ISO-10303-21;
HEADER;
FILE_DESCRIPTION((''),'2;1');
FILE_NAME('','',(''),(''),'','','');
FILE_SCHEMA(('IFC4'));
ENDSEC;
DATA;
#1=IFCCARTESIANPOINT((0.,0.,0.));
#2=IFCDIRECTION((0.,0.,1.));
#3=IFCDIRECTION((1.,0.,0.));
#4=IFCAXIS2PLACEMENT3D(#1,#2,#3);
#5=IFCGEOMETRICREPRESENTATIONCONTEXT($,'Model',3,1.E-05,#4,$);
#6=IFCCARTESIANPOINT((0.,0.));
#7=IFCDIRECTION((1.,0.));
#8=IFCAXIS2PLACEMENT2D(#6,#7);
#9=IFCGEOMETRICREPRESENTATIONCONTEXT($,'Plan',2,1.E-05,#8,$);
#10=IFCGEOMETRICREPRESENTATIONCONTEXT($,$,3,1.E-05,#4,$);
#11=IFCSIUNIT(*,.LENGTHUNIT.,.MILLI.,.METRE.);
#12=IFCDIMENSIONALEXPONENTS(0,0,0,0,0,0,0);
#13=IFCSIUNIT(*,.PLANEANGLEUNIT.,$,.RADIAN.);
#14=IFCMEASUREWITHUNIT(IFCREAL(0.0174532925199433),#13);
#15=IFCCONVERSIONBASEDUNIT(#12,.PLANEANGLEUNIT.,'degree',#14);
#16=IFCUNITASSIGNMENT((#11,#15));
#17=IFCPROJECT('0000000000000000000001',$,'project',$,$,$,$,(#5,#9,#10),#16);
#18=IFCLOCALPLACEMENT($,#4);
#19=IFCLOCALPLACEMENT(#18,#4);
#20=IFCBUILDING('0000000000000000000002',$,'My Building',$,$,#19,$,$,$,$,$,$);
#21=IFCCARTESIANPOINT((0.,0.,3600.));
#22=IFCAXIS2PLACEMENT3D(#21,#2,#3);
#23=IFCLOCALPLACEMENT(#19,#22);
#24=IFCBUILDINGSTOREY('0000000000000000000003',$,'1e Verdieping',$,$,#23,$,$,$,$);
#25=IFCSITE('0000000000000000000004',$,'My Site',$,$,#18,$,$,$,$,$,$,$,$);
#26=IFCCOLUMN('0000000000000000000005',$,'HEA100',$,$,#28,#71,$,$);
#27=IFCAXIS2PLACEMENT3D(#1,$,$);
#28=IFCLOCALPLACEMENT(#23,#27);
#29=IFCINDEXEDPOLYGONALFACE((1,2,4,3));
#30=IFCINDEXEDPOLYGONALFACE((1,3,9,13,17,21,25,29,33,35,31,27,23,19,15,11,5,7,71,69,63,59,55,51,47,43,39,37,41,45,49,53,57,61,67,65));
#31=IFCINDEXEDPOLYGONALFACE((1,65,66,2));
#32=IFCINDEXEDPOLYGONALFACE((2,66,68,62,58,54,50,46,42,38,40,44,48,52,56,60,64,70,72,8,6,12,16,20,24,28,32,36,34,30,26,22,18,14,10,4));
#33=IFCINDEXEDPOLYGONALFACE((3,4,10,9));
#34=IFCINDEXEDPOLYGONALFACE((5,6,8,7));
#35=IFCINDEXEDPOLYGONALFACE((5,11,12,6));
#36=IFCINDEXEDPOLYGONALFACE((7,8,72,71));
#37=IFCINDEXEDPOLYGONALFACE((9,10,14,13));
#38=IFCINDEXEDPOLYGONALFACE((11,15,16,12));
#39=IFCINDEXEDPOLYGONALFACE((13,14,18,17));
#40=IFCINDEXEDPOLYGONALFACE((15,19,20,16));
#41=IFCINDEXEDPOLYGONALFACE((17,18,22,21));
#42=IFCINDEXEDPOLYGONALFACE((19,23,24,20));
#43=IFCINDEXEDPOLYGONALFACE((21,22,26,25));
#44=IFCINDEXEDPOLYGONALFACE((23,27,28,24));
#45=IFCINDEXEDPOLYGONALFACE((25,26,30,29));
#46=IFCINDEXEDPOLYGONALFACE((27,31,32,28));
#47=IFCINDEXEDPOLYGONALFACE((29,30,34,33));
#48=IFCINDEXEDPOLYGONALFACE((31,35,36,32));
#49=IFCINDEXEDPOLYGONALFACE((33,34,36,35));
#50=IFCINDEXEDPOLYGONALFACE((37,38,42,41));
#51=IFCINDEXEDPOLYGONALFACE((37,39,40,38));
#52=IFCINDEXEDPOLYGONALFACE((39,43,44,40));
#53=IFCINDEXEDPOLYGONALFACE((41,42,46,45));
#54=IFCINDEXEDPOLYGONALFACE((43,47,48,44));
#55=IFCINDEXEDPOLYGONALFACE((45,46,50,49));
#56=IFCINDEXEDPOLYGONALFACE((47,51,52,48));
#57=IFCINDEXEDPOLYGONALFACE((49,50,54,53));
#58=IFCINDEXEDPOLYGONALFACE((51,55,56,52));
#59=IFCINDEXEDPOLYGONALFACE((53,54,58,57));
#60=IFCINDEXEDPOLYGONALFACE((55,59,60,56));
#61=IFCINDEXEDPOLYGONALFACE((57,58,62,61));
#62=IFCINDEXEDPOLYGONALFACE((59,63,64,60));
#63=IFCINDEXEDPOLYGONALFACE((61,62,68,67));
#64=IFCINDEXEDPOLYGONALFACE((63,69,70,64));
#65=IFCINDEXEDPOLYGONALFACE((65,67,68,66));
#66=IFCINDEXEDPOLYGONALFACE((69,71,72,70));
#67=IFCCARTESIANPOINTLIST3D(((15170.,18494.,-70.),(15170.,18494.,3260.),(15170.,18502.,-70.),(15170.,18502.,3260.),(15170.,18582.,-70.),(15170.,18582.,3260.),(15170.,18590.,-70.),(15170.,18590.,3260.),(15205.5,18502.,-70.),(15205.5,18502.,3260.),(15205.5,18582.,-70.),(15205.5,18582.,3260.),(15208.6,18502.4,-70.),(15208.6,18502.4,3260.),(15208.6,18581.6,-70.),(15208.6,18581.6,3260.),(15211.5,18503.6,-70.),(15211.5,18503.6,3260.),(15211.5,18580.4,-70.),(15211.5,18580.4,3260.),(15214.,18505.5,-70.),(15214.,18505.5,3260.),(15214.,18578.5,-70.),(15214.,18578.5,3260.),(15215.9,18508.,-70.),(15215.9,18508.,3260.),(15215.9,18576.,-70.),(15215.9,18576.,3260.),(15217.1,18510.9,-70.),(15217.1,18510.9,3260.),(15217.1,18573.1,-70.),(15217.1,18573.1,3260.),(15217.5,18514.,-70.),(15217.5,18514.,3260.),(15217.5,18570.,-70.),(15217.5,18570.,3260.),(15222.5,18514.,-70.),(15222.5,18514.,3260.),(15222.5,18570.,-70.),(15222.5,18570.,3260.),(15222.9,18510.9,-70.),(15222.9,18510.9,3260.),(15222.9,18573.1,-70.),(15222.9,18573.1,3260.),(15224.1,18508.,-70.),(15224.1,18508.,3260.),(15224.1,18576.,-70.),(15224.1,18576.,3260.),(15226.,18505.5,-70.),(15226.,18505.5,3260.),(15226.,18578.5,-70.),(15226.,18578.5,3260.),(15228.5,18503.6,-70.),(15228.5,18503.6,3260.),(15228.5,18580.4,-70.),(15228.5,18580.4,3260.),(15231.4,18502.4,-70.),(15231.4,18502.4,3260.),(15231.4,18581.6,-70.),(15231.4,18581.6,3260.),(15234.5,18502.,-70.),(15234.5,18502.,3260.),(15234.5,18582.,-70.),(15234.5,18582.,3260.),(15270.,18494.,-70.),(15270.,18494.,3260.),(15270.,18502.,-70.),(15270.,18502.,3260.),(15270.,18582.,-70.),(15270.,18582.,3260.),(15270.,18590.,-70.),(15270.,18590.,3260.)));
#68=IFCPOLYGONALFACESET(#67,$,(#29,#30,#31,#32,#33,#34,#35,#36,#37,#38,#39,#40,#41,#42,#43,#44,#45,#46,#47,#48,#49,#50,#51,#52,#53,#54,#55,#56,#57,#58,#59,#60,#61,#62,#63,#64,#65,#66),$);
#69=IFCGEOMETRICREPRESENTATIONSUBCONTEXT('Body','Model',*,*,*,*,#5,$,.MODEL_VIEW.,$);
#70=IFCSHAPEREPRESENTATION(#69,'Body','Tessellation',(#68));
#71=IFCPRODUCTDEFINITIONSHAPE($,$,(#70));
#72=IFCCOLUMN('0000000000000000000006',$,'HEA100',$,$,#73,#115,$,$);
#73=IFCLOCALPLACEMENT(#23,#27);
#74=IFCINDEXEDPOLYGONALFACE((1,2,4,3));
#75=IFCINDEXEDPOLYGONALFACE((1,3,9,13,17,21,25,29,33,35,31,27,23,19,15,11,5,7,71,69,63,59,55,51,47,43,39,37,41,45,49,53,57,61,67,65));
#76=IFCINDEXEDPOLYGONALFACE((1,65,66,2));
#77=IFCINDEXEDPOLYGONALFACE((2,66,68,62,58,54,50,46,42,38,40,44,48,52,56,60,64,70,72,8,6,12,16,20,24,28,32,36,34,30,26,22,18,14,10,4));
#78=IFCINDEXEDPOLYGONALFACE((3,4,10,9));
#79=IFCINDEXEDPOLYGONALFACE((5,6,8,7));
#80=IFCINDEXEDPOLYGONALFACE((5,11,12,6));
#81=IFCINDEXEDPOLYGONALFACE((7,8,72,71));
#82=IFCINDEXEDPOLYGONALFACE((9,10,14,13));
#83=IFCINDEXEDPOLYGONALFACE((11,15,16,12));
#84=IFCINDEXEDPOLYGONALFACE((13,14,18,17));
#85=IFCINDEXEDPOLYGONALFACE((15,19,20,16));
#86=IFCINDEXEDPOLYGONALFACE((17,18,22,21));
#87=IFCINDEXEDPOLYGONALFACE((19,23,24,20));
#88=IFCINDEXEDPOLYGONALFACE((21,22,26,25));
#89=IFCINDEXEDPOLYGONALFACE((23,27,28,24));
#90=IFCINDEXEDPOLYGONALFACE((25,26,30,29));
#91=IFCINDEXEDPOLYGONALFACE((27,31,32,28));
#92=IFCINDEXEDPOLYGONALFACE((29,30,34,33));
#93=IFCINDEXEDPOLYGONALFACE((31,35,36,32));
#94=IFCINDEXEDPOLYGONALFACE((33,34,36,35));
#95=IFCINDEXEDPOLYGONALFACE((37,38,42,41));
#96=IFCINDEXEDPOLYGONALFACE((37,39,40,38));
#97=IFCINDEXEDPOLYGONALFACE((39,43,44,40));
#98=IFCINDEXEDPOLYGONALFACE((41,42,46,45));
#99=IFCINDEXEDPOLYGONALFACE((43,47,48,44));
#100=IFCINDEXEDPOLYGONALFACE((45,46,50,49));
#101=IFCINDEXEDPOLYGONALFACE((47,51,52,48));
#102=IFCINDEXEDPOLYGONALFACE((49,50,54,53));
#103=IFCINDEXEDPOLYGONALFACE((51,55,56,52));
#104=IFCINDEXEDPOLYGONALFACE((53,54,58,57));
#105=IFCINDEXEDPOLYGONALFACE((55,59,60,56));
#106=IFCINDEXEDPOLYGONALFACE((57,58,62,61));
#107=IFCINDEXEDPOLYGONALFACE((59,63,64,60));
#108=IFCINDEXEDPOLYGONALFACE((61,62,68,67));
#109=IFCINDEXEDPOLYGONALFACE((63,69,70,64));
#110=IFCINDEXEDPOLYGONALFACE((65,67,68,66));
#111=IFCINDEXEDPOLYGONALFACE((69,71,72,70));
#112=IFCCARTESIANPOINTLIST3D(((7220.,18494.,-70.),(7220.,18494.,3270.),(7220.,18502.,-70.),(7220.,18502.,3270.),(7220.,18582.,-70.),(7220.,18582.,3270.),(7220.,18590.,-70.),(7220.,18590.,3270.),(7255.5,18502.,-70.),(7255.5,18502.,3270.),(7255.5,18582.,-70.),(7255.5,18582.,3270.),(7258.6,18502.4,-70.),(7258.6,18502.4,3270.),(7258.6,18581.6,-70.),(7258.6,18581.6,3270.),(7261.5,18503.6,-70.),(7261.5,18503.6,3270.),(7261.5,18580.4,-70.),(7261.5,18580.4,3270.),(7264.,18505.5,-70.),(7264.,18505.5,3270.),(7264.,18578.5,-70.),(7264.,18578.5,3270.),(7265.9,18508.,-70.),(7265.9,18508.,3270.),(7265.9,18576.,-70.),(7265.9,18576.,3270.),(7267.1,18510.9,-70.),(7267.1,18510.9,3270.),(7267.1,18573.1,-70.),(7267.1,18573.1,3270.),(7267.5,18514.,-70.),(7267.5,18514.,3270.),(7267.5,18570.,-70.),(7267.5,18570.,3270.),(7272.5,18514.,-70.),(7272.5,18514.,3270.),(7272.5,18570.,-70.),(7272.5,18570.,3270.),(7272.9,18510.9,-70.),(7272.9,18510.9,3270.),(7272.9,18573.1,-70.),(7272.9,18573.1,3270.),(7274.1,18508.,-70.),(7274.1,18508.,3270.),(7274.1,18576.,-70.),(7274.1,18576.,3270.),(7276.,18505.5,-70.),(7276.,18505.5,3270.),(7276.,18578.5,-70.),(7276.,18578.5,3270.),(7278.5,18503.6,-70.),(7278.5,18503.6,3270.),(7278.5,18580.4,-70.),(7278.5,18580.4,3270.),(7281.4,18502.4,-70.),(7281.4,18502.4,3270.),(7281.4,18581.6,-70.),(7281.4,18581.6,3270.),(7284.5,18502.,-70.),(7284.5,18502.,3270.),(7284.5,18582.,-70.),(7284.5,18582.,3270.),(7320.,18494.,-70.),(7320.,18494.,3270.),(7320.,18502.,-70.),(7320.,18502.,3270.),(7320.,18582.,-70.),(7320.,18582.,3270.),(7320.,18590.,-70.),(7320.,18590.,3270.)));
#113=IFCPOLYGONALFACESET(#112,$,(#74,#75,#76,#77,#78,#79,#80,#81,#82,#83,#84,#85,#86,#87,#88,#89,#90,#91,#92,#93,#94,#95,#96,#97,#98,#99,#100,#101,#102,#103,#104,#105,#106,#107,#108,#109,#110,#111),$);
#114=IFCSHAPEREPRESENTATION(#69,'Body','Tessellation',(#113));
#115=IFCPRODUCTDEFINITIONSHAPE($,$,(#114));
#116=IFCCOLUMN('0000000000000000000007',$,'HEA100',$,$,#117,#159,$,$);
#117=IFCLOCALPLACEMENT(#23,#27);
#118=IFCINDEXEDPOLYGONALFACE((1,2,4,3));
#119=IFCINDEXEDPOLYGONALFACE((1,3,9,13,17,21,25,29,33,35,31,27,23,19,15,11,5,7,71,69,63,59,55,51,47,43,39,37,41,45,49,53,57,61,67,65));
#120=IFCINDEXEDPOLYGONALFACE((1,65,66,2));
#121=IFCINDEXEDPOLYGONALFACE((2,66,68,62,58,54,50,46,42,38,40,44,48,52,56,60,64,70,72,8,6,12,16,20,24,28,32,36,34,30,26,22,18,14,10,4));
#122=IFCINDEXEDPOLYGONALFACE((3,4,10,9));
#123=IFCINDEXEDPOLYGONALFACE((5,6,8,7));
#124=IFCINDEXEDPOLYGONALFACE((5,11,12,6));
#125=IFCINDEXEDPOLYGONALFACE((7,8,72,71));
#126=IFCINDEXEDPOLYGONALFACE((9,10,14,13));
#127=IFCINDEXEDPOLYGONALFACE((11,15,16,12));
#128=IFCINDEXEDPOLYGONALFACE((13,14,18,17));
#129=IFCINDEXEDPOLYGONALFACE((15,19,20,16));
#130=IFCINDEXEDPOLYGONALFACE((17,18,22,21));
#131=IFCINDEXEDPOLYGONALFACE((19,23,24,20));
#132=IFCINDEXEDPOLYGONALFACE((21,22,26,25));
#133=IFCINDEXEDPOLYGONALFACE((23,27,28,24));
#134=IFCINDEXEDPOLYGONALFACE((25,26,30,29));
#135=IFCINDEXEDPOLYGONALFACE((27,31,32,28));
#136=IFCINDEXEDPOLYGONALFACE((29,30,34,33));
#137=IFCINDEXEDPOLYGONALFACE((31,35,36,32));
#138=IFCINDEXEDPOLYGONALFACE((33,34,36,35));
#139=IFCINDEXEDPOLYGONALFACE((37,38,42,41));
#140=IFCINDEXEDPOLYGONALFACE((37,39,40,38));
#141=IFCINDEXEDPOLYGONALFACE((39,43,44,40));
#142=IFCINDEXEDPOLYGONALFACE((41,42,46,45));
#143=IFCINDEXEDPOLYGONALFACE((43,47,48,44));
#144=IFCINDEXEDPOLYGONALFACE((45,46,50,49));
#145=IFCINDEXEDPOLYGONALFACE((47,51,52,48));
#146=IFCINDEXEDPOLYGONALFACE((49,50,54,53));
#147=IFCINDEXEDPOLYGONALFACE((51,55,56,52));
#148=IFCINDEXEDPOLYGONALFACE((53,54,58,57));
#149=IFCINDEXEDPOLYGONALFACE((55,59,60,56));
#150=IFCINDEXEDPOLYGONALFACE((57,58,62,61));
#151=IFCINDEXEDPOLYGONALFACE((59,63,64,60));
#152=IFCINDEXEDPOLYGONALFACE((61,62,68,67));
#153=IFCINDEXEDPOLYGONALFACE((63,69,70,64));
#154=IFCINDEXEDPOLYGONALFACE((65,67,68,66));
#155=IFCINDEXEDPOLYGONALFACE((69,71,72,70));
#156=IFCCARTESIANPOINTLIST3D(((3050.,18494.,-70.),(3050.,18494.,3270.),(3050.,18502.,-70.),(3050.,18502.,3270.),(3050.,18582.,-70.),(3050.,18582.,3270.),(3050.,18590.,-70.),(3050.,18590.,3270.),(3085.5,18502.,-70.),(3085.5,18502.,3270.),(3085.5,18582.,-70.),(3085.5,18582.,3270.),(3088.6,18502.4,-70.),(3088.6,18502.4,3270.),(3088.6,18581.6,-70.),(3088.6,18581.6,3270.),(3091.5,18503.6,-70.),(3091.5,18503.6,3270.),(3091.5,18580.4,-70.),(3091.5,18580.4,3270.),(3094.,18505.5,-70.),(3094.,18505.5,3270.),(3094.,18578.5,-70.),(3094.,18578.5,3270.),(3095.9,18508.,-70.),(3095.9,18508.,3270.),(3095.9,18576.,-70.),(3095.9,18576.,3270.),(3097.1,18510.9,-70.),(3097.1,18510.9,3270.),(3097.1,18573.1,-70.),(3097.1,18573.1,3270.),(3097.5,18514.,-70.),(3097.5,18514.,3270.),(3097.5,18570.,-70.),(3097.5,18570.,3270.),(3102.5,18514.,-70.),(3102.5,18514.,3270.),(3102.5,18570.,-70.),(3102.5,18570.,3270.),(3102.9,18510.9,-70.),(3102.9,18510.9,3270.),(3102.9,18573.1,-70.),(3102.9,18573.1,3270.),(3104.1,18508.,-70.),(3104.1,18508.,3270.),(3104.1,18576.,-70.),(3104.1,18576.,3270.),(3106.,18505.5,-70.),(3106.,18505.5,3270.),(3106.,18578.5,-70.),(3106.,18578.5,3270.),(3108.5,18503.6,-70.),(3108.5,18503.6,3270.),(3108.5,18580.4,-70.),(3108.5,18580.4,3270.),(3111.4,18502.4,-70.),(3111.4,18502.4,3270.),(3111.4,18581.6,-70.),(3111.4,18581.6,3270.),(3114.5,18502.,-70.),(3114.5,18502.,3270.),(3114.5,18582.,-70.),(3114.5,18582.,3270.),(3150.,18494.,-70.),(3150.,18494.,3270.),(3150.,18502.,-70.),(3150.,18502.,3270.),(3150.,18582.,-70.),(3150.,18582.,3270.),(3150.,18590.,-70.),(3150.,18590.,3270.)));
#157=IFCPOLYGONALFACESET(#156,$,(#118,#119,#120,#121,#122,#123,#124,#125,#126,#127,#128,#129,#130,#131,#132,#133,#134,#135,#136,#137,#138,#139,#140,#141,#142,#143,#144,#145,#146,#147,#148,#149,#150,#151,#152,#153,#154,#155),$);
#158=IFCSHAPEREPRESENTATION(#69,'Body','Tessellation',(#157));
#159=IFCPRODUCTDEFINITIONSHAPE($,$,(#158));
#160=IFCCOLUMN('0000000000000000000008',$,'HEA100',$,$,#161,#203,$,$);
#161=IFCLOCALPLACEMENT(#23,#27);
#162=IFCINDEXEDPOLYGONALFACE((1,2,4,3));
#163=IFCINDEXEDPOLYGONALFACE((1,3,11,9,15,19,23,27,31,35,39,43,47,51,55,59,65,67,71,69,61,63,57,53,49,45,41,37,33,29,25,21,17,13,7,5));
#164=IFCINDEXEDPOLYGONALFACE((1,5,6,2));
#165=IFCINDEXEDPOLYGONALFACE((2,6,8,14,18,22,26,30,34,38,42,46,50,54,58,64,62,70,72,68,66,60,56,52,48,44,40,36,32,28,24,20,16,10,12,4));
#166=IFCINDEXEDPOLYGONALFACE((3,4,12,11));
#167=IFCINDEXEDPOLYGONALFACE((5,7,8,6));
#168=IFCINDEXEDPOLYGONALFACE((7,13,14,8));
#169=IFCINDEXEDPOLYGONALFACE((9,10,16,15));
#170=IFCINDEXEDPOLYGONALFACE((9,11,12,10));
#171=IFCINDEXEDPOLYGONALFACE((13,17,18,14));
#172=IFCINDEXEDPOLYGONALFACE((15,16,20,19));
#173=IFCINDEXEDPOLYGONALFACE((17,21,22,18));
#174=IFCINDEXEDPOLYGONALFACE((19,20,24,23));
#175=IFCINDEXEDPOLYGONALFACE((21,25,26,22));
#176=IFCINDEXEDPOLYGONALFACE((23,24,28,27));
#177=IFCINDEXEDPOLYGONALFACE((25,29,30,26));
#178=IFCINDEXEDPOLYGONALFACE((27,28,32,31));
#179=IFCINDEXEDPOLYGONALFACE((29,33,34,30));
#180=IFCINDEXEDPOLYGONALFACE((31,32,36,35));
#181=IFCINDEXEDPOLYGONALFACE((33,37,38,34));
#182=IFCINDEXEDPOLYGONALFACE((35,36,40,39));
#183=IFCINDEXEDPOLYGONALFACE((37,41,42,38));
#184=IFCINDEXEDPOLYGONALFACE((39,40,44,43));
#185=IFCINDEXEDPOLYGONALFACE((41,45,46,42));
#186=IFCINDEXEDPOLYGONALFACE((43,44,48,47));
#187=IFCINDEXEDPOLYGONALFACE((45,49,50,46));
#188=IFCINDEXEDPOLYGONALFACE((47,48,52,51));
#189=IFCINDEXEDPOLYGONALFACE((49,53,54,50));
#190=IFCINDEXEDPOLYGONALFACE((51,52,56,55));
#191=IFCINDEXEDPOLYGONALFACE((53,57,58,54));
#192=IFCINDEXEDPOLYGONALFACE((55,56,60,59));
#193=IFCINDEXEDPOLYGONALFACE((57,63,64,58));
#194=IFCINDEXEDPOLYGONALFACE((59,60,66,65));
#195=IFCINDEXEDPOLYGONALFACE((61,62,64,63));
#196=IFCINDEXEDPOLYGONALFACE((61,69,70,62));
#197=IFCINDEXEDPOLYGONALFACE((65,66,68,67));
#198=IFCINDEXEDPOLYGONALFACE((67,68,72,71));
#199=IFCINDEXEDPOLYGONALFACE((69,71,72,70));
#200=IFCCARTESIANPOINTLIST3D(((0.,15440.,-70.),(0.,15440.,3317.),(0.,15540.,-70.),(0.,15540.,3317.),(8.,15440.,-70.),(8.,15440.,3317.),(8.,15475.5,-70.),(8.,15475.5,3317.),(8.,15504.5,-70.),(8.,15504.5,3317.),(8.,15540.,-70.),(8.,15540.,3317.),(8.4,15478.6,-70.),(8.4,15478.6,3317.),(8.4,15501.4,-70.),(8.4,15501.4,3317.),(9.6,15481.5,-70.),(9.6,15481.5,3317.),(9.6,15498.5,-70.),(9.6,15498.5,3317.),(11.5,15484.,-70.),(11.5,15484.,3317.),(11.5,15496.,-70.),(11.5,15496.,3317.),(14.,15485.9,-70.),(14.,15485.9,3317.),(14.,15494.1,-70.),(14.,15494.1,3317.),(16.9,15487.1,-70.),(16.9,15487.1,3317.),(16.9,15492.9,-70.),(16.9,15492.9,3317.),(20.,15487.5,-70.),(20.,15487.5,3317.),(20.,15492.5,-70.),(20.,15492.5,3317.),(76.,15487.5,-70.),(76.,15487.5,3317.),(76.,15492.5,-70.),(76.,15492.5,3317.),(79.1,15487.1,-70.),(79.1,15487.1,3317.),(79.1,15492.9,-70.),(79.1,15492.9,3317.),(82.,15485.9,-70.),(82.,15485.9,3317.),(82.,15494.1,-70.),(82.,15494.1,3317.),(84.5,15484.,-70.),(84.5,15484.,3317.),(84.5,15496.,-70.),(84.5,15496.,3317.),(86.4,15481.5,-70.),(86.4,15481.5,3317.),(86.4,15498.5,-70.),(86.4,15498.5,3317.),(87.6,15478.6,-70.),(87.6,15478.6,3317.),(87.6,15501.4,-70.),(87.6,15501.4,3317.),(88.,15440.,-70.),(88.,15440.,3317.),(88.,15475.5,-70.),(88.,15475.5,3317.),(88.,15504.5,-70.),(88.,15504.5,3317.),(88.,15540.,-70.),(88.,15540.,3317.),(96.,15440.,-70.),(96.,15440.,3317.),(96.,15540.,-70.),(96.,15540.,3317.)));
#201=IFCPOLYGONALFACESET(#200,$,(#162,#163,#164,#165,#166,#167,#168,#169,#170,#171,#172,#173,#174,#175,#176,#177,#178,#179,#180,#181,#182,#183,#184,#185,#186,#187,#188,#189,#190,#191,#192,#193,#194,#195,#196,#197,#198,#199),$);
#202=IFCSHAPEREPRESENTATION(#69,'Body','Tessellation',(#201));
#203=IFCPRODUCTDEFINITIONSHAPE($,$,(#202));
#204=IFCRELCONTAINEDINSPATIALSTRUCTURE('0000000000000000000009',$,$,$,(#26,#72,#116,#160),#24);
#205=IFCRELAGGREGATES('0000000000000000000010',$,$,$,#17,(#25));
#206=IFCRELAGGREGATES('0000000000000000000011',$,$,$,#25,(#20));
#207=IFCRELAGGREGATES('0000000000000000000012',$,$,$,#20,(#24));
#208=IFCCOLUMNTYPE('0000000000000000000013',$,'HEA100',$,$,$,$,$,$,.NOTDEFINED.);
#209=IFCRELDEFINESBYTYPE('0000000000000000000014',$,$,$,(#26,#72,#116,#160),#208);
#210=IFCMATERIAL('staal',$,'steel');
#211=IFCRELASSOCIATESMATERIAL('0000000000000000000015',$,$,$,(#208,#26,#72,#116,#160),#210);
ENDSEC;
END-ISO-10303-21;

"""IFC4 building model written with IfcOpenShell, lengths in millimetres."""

from ifc_helpers import new_model, entity, si_unit, converted_unit, frame, origin_with_axes, origin_2d_with_axis, place, context, subcontext, project, spatial, i_section, extrude, material, material_profile, profile_set, profile_usage, type_object, element, save


model = new_model("IFC4")

# Units and contexts
model_context = context("Model", 3, precision=1e-05, world=origin_with_axes())
plan_context = context("Plan", 2, precision=1e-05, world=origin_2d_with_axis())
context_of_model = context(None, 3, precision=1e-05, world=origin_with_axes())
body_context = subcontext(model_context, "Body", "Model", "MODEL_VIEW")
ifc_project = project(units=[si_unit("LENGTHUNIT", "METRE", prefix="MILLI"), converted_unit("PLANEANGLEUNIT", "degree", entity("IfcReal", 0.0174532925199433), si_unit("PLANEANGLEUNIT", "RADIAN"), dimensions=[0, 0, 0, 0, 0, 0, 0])], contexts=[model_context, plan_context, context_of_model])

# Site, building, storey
site_placement = place(None, origin_with_axes())
site = spatial("IfcSite", under=ifc_project, at=site_placement, Name="My Site")
building_placement = place(site_placement, origin_with_axes())
building = spatial("IfcBuilding", under=site, at=building_placement, Name="My Building")
storey_placement = place(building_placement, frame((0.0, 0.0, 3600.0), z_axis=(0.0, 0.0, 1.0), x_axis=(1.0, 0.0, 0.0)))
storey = spatial("IfcBuildingStorey", under=building, at=storey_placement, Name="1e Verdieping")

# Columns
ifc_material_1 = material(Name="staal", Category="steel")
ifc_material_profile_1 = material_profile(ifc_material_1, i_section(OverallWidth=100.0, OverallDepth=96.0, WebThickness=5.0, FlangeThickness=8.0, FilletRadius=12.0))
ifc_profile_set_1 = profile_set([ifc_material_profile_1], Name="HEA100")
column_type_1 = type_object("IfcColumnType", Name="HEA100", PredefinedType="NOTDEFINED", material=ifc_profile_set_1)
ifc_profile_usage_1 = profile_usage(ifc_profile_set_1)
column_1_placement = place(storey_placement, frame((15220.0, 18542.0, -70.0), z_axis=(0.0, 0.0, 1.0), x_axis=(1.0, 0.0, 0.0)))
element("IfcColumn", 1, at=column_1_placement, inside=storey, type_object=column_type_1, material=ifc_profile_usage_1, Name="HEA100", context=body_context, shape_type="SweptSolid", body=[
    extrude(i_section(OverallWidth=100.0, OverallDepth=96.0, WebThickness=5.0, FlangeThickness=8.0, FilletRadius=12.0), origin_with_axes(), (0.0, 0.0, 1.0), 3330.0),
])
ifc_profile_usage_2 = profile_usage(ifc_profile_set_1)
column_2_placement = place(storey_placement, frame((7270.0, 18542.0, -70.0), z_axis=(0.0, 0.0, 1.0), x_axis=(1.0, 0.0, 0.0)))
element("IfcColumn", 2, at=column_2_placement, inside=storey, type_object=column_type_1, material=ifc_profile_usage_2, Name="HEA100", context=body_context, shape_type="SweptSolid", body=[
    extrude(i_section(OverallWidth=100.0, OverallDepth=96.0, WebThickness=5.0, FlangeThickness=8.0, FilletRadius=12.0), origin_with_axes(), (0.0, 0.0, 1.0), 3340.0),
])
ifc_profile_usage_3 = profile_usage(ifc_profile_set_1)
column_3_placement = place(storey_placement, frame((3100.0, 18542.0, -70.0), z_axis=(0.0, 0.0, 1.0), x_axis=(1.0, 0.0, 0.0)))
element("IfcColumn", 3, at=column_3_placement, inside=storey, type_object=column_type_1, material=ifc_profile_usage_3, Name="HEA100", context=body_context, shape_type="SweptSolid", body=[
    extrude(i_section(OverallWidth=100.0, OverallDepth=96.0, WebThickness=5.0, FlangeThickness=8.0, FilletRadius=12.0), origin_with_axes(), (0.0, 0.0, 1.0), 3340.0),
])
ifc_profile_usage_4 = profile_usage(ifc_profile_set_1)
column_4_placement = place(storey_placement, frame((48.0, 15490.0, -70.0), z_axis=(0.0, 0.0, 1.0), x_axis=(0.0, 1.0, 0.0)))
element("IfcColumn", 4, at=column_4_placement, inside=storey, type_object=column_type_1, material=ifc_profile_usage_4, Name="HEA100", context=body_context, shape_type="SweptSolid", body=[
    extrude(i_section(OverallWidth=100.0, OverallDepth=96.0, WebThickness=5.0, FlangeThickness=8.0, FilletRadius=12.0), origin_with_axes(), (0.0, 0.0, 1.0), 3387.0),
])

save(model, "model.ifc")
